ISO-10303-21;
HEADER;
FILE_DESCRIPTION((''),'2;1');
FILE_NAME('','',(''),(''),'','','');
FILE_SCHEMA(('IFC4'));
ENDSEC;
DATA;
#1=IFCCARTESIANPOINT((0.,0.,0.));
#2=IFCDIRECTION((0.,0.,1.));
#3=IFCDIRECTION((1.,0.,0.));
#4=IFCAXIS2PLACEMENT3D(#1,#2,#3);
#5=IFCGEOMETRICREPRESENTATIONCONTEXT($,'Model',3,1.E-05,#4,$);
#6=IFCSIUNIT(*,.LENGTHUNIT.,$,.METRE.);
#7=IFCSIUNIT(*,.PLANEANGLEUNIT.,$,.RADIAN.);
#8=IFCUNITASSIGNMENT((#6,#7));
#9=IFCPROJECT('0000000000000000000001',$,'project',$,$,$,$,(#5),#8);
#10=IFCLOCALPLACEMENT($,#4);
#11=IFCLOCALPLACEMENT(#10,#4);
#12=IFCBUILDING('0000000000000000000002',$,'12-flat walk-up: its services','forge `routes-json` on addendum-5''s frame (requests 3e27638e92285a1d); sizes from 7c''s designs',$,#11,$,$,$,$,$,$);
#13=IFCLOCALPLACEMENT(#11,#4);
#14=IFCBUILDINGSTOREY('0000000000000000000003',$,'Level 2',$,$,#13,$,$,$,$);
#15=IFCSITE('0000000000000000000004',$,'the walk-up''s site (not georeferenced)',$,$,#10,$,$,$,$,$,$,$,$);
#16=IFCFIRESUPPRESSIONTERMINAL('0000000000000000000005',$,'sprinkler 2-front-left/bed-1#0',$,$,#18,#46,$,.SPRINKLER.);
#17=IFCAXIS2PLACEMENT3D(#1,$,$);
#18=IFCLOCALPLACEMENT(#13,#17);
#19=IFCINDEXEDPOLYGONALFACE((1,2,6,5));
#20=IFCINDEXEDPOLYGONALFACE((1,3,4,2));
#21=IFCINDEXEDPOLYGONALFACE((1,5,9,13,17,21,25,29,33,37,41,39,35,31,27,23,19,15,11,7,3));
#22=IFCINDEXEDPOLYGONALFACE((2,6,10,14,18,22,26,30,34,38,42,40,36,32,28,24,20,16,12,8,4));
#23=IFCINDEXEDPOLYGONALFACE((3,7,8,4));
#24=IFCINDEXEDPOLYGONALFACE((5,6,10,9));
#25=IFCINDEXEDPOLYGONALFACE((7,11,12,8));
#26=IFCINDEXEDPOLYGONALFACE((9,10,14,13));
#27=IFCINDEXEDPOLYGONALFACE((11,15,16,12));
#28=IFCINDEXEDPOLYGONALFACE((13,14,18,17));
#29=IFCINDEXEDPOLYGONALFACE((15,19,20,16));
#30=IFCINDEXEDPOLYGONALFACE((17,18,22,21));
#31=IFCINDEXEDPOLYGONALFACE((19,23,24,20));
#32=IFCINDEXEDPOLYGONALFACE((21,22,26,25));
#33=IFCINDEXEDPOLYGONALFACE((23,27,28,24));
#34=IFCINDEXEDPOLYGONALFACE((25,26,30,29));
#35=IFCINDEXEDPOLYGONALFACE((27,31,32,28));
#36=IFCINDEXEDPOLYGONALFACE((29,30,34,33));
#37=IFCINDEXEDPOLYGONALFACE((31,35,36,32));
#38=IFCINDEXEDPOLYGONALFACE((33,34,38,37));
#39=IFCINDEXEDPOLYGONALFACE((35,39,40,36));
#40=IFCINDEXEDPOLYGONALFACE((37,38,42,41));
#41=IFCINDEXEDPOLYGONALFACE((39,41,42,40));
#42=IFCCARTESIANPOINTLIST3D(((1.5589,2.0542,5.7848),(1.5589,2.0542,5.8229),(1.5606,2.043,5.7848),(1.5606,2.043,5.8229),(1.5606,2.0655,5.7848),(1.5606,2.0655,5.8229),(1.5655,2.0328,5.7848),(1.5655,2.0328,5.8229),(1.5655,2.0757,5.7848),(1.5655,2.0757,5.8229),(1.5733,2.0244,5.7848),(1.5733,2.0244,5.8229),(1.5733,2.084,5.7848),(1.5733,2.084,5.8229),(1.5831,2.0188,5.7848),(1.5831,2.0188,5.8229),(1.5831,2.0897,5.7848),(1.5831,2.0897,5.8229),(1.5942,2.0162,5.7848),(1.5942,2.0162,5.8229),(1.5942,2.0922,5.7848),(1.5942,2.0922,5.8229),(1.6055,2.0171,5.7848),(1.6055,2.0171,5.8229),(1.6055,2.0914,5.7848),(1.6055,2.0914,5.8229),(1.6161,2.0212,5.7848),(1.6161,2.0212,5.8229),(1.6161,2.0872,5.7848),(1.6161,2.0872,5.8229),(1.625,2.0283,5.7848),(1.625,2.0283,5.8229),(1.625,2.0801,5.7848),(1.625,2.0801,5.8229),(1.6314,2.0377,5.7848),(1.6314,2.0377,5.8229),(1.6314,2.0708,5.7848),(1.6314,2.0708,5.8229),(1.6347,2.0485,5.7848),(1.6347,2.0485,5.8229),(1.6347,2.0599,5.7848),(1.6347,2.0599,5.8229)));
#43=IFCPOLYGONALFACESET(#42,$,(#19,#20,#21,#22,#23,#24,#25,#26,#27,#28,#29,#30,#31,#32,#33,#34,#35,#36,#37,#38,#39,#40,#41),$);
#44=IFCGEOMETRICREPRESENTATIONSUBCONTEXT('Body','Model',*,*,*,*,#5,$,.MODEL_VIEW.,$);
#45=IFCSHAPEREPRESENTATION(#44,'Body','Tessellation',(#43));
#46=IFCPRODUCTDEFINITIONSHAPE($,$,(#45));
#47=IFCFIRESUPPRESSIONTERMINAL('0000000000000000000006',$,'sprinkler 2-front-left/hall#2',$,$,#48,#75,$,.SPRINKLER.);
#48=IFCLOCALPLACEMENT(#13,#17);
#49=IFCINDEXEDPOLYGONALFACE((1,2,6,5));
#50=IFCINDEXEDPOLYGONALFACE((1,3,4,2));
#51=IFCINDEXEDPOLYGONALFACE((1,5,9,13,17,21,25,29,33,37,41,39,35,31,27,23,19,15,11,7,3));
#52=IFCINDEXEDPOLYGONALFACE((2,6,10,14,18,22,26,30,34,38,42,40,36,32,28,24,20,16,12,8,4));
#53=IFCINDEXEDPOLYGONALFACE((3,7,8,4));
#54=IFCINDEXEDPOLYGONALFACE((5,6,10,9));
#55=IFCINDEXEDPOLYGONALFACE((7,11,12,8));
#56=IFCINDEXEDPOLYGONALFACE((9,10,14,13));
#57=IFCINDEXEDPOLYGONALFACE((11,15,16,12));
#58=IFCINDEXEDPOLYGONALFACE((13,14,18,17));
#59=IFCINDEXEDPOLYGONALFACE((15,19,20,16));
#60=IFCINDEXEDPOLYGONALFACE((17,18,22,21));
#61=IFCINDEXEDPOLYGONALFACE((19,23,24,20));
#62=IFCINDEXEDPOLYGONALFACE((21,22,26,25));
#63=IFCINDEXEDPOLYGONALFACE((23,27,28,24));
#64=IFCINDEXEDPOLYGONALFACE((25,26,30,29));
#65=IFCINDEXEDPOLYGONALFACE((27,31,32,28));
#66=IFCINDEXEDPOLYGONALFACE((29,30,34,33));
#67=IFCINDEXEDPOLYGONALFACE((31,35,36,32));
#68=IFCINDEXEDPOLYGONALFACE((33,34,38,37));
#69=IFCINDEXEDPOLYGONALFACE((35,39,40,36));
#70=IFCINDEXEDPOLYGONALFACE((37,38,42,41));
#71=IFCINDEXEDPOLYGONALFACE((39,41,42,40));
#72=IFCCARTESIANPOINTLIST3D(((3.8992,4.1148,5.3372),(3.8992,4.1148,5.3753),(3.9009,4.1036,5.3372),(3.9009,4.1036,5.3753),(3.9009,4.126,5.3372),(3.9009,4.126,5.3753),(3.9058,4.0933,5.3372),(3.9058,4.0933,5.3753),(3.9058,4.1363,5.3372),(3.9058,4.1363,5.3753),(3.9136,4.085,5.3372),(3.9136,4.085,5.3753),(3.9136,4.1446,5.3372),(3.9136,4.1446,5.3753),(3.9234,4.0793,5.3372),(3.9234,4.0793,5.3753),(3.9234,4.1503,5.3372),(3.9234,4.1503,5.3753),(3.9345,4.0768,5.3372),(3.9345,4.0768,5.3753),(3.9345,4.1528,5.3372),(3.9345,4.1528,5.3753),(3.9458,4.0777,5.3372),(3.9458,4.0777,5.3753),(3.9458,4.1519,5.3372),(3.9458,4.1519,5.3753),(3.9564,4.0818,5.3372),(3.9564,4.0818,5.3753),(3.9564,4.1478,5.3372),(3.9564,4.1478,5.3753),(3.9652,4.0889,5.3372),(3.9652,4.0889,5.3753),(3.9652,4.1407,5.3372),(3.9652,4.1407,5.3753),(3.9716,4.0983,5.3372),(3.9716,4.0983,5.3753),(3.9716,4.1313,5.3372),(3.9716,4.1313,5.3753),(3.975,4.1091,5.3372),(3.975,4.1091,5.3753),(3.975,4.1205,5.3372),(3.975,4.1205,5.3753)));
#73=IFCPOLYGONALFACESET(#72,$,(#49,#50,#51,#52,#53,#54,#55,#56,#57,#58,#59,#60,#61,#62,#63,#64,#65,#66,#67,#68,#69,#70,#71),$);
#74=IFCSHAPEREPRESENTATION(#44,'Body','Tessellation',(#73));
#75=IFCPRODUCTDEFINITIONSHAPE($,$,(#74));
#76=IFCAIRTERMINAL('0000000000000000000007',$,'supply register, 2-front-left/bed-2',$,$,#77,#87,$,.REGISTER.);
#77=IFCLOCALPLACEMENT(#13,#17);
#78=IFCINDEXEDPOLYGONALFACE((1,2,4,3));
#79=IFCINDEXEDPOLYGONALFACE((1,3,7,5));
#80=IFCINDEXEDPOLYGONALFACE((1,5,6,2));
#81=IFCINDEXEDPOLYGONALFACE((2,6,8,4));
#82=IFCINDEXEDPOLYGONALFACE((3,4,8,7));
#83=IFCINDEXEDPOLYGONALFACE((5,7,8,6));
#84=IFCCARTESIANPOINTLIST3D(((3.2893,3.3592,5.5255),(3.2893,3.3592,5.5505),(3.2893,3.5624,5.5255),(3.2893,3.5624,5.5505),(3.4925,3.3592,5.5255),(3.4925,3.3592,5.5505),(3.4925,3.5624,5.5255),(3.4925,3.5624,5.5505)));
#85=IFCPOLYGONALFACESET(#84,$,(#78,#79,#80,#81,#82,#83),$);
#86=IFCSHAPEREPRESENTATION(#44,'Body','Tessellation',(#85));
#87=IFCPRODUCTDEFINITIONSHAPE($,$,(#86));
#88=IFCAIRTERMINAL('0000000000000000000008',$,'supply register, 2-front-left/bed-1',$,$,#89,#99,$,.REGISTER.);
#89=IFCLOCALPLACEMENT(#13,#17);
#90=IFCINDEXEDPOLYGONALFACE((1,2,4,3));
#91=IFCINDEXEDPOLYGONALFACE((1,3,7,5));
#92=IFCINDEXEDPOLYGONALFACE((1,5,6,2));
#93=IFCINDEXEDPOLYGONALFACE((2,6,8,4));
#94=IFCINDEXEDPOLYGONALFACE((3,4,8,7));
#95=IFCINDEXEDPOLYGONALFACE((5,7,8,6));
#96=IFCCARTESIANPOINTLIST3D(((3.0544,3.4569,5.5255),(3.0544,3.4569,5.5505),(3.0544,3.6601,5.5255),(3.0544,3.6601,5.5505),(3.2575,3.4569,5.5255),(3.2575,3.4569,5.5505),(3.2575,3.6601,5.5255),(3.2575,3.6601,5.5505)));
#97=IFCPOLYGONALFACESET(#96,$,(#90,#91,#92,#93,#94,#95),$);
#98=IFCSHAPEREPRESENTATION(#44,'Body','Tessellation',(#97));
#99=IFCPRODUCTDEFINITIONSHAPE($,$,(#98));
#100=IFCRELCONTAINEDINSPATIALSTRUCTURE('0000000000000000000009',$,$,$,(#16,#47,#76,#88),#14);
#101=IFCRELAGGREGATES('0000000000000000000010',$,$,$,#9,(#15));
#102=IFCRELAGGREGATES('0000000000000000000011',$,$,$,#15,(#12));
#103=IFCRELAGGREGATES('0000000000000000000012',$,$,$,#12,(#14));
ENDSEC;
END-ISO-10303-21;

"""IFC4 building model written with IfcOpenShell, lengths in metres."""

from ifc_helpers import new_model, entity, si_unit, frame, frame_2d, origin, origin_with_axes, place, context, subcontext, project, spatial, rectangle, extrude, element, save


model = new_model("IFC4")

# Units and contexts
model_context = context("Model", 3, precision=1e-05, world=origin_with_axes())
body_context = subcontext(model_context, "Body", "Model", "MODEL_VIEW")
ifc_project = project(units=[si_unit("LENGTHUNIT", "METRE"), si_unit("PLANEANGLEUNIT", "RADIAN")], contexts=[model_context])

# Site, building, storey
site_placement = place(None, origin_with_axes())
site = spatial("IfcSite", under=ifc_project, at=site_placement, Name="the walk-up's site (not georeferenced)")
building_placement = place(site_placement, origin_with_axes())
building = spatial("IfcBuilding", under=site, at=building_placement, Name="12-flat walk-up: its services", Description="forge `routes-json` on addendum-5's frame (requests 3e27638e92285a1d); sizes from 7c's designs")
storey_placement = place(building_placement, origin_with_axes())
storey = spatial("IfcBuildingStorey", under=building, at=storey_placement, Name="Level 2")

# Fire suppression terminals
for number, where, z_axis, x_axis, name in (
    (1, (1.597, 2.0542, 5.8229), (0.0, 0.0, 1.0), (1.0, 0.0, 0.0), "sprinkler 2-front-left/bed-1#0"),
    (2, (3.9373, 4.1148, 5.3753), (0.0, 0.0, 1.0), (1.0, 0.0, 0.0), "sprinkler 2-front-left/hall#2"),
):
    element("IfcFireSuppressionTerminal", number, at=place(storey_placement, frame(where, z_axis=z_axis, x_axis=x_axis)), inside=storey, Name=name, PredefinedType="SPRINKLER", context=body_context, shape_type="AdvancedSweptSolid", body=[
        entity("IfcSweptDiskSolid", entity("IfcPolyline", [entity("IfcCartesianPoint", [0.0, 0.0, 0.0]), entity("IfcCartesianPoint", [0.0, 0.0, -0.0381])]), 0.0381),
    ])

# Air terminals
for number, where, z_axis, x_axis, name in (
    (3, (3.2893, 3.3592, 5.5255), (0.0, 0.0, 1.0), (1.0, 0.0, 0.0), "supply register, 2-front-left/bed-2"),
    (4, (3.0543, 3.4569, 5.5255), (0.0, 0.0, 1.0), (1.0, 0.0, 0.0), "supply register, 2-front-left/bed-1"),
):
    element("IfcAirTerminal", number, at=place(storey_placement, frame(where, z_axis=z_axis, x_axis=x_axis)), inside=storey, Name=name, PredefinedType="REGISTER", context=body_context, shape_type="SweptSolid", body=[
        extrude(rectangle(XDim=0.2032, YDim=0.2032, at=frame_2d((0.1016, 0.1016))), origin(), (0.0, 0.0, 1.0), 0.025),
    ])

save(model, "model.ifc")
